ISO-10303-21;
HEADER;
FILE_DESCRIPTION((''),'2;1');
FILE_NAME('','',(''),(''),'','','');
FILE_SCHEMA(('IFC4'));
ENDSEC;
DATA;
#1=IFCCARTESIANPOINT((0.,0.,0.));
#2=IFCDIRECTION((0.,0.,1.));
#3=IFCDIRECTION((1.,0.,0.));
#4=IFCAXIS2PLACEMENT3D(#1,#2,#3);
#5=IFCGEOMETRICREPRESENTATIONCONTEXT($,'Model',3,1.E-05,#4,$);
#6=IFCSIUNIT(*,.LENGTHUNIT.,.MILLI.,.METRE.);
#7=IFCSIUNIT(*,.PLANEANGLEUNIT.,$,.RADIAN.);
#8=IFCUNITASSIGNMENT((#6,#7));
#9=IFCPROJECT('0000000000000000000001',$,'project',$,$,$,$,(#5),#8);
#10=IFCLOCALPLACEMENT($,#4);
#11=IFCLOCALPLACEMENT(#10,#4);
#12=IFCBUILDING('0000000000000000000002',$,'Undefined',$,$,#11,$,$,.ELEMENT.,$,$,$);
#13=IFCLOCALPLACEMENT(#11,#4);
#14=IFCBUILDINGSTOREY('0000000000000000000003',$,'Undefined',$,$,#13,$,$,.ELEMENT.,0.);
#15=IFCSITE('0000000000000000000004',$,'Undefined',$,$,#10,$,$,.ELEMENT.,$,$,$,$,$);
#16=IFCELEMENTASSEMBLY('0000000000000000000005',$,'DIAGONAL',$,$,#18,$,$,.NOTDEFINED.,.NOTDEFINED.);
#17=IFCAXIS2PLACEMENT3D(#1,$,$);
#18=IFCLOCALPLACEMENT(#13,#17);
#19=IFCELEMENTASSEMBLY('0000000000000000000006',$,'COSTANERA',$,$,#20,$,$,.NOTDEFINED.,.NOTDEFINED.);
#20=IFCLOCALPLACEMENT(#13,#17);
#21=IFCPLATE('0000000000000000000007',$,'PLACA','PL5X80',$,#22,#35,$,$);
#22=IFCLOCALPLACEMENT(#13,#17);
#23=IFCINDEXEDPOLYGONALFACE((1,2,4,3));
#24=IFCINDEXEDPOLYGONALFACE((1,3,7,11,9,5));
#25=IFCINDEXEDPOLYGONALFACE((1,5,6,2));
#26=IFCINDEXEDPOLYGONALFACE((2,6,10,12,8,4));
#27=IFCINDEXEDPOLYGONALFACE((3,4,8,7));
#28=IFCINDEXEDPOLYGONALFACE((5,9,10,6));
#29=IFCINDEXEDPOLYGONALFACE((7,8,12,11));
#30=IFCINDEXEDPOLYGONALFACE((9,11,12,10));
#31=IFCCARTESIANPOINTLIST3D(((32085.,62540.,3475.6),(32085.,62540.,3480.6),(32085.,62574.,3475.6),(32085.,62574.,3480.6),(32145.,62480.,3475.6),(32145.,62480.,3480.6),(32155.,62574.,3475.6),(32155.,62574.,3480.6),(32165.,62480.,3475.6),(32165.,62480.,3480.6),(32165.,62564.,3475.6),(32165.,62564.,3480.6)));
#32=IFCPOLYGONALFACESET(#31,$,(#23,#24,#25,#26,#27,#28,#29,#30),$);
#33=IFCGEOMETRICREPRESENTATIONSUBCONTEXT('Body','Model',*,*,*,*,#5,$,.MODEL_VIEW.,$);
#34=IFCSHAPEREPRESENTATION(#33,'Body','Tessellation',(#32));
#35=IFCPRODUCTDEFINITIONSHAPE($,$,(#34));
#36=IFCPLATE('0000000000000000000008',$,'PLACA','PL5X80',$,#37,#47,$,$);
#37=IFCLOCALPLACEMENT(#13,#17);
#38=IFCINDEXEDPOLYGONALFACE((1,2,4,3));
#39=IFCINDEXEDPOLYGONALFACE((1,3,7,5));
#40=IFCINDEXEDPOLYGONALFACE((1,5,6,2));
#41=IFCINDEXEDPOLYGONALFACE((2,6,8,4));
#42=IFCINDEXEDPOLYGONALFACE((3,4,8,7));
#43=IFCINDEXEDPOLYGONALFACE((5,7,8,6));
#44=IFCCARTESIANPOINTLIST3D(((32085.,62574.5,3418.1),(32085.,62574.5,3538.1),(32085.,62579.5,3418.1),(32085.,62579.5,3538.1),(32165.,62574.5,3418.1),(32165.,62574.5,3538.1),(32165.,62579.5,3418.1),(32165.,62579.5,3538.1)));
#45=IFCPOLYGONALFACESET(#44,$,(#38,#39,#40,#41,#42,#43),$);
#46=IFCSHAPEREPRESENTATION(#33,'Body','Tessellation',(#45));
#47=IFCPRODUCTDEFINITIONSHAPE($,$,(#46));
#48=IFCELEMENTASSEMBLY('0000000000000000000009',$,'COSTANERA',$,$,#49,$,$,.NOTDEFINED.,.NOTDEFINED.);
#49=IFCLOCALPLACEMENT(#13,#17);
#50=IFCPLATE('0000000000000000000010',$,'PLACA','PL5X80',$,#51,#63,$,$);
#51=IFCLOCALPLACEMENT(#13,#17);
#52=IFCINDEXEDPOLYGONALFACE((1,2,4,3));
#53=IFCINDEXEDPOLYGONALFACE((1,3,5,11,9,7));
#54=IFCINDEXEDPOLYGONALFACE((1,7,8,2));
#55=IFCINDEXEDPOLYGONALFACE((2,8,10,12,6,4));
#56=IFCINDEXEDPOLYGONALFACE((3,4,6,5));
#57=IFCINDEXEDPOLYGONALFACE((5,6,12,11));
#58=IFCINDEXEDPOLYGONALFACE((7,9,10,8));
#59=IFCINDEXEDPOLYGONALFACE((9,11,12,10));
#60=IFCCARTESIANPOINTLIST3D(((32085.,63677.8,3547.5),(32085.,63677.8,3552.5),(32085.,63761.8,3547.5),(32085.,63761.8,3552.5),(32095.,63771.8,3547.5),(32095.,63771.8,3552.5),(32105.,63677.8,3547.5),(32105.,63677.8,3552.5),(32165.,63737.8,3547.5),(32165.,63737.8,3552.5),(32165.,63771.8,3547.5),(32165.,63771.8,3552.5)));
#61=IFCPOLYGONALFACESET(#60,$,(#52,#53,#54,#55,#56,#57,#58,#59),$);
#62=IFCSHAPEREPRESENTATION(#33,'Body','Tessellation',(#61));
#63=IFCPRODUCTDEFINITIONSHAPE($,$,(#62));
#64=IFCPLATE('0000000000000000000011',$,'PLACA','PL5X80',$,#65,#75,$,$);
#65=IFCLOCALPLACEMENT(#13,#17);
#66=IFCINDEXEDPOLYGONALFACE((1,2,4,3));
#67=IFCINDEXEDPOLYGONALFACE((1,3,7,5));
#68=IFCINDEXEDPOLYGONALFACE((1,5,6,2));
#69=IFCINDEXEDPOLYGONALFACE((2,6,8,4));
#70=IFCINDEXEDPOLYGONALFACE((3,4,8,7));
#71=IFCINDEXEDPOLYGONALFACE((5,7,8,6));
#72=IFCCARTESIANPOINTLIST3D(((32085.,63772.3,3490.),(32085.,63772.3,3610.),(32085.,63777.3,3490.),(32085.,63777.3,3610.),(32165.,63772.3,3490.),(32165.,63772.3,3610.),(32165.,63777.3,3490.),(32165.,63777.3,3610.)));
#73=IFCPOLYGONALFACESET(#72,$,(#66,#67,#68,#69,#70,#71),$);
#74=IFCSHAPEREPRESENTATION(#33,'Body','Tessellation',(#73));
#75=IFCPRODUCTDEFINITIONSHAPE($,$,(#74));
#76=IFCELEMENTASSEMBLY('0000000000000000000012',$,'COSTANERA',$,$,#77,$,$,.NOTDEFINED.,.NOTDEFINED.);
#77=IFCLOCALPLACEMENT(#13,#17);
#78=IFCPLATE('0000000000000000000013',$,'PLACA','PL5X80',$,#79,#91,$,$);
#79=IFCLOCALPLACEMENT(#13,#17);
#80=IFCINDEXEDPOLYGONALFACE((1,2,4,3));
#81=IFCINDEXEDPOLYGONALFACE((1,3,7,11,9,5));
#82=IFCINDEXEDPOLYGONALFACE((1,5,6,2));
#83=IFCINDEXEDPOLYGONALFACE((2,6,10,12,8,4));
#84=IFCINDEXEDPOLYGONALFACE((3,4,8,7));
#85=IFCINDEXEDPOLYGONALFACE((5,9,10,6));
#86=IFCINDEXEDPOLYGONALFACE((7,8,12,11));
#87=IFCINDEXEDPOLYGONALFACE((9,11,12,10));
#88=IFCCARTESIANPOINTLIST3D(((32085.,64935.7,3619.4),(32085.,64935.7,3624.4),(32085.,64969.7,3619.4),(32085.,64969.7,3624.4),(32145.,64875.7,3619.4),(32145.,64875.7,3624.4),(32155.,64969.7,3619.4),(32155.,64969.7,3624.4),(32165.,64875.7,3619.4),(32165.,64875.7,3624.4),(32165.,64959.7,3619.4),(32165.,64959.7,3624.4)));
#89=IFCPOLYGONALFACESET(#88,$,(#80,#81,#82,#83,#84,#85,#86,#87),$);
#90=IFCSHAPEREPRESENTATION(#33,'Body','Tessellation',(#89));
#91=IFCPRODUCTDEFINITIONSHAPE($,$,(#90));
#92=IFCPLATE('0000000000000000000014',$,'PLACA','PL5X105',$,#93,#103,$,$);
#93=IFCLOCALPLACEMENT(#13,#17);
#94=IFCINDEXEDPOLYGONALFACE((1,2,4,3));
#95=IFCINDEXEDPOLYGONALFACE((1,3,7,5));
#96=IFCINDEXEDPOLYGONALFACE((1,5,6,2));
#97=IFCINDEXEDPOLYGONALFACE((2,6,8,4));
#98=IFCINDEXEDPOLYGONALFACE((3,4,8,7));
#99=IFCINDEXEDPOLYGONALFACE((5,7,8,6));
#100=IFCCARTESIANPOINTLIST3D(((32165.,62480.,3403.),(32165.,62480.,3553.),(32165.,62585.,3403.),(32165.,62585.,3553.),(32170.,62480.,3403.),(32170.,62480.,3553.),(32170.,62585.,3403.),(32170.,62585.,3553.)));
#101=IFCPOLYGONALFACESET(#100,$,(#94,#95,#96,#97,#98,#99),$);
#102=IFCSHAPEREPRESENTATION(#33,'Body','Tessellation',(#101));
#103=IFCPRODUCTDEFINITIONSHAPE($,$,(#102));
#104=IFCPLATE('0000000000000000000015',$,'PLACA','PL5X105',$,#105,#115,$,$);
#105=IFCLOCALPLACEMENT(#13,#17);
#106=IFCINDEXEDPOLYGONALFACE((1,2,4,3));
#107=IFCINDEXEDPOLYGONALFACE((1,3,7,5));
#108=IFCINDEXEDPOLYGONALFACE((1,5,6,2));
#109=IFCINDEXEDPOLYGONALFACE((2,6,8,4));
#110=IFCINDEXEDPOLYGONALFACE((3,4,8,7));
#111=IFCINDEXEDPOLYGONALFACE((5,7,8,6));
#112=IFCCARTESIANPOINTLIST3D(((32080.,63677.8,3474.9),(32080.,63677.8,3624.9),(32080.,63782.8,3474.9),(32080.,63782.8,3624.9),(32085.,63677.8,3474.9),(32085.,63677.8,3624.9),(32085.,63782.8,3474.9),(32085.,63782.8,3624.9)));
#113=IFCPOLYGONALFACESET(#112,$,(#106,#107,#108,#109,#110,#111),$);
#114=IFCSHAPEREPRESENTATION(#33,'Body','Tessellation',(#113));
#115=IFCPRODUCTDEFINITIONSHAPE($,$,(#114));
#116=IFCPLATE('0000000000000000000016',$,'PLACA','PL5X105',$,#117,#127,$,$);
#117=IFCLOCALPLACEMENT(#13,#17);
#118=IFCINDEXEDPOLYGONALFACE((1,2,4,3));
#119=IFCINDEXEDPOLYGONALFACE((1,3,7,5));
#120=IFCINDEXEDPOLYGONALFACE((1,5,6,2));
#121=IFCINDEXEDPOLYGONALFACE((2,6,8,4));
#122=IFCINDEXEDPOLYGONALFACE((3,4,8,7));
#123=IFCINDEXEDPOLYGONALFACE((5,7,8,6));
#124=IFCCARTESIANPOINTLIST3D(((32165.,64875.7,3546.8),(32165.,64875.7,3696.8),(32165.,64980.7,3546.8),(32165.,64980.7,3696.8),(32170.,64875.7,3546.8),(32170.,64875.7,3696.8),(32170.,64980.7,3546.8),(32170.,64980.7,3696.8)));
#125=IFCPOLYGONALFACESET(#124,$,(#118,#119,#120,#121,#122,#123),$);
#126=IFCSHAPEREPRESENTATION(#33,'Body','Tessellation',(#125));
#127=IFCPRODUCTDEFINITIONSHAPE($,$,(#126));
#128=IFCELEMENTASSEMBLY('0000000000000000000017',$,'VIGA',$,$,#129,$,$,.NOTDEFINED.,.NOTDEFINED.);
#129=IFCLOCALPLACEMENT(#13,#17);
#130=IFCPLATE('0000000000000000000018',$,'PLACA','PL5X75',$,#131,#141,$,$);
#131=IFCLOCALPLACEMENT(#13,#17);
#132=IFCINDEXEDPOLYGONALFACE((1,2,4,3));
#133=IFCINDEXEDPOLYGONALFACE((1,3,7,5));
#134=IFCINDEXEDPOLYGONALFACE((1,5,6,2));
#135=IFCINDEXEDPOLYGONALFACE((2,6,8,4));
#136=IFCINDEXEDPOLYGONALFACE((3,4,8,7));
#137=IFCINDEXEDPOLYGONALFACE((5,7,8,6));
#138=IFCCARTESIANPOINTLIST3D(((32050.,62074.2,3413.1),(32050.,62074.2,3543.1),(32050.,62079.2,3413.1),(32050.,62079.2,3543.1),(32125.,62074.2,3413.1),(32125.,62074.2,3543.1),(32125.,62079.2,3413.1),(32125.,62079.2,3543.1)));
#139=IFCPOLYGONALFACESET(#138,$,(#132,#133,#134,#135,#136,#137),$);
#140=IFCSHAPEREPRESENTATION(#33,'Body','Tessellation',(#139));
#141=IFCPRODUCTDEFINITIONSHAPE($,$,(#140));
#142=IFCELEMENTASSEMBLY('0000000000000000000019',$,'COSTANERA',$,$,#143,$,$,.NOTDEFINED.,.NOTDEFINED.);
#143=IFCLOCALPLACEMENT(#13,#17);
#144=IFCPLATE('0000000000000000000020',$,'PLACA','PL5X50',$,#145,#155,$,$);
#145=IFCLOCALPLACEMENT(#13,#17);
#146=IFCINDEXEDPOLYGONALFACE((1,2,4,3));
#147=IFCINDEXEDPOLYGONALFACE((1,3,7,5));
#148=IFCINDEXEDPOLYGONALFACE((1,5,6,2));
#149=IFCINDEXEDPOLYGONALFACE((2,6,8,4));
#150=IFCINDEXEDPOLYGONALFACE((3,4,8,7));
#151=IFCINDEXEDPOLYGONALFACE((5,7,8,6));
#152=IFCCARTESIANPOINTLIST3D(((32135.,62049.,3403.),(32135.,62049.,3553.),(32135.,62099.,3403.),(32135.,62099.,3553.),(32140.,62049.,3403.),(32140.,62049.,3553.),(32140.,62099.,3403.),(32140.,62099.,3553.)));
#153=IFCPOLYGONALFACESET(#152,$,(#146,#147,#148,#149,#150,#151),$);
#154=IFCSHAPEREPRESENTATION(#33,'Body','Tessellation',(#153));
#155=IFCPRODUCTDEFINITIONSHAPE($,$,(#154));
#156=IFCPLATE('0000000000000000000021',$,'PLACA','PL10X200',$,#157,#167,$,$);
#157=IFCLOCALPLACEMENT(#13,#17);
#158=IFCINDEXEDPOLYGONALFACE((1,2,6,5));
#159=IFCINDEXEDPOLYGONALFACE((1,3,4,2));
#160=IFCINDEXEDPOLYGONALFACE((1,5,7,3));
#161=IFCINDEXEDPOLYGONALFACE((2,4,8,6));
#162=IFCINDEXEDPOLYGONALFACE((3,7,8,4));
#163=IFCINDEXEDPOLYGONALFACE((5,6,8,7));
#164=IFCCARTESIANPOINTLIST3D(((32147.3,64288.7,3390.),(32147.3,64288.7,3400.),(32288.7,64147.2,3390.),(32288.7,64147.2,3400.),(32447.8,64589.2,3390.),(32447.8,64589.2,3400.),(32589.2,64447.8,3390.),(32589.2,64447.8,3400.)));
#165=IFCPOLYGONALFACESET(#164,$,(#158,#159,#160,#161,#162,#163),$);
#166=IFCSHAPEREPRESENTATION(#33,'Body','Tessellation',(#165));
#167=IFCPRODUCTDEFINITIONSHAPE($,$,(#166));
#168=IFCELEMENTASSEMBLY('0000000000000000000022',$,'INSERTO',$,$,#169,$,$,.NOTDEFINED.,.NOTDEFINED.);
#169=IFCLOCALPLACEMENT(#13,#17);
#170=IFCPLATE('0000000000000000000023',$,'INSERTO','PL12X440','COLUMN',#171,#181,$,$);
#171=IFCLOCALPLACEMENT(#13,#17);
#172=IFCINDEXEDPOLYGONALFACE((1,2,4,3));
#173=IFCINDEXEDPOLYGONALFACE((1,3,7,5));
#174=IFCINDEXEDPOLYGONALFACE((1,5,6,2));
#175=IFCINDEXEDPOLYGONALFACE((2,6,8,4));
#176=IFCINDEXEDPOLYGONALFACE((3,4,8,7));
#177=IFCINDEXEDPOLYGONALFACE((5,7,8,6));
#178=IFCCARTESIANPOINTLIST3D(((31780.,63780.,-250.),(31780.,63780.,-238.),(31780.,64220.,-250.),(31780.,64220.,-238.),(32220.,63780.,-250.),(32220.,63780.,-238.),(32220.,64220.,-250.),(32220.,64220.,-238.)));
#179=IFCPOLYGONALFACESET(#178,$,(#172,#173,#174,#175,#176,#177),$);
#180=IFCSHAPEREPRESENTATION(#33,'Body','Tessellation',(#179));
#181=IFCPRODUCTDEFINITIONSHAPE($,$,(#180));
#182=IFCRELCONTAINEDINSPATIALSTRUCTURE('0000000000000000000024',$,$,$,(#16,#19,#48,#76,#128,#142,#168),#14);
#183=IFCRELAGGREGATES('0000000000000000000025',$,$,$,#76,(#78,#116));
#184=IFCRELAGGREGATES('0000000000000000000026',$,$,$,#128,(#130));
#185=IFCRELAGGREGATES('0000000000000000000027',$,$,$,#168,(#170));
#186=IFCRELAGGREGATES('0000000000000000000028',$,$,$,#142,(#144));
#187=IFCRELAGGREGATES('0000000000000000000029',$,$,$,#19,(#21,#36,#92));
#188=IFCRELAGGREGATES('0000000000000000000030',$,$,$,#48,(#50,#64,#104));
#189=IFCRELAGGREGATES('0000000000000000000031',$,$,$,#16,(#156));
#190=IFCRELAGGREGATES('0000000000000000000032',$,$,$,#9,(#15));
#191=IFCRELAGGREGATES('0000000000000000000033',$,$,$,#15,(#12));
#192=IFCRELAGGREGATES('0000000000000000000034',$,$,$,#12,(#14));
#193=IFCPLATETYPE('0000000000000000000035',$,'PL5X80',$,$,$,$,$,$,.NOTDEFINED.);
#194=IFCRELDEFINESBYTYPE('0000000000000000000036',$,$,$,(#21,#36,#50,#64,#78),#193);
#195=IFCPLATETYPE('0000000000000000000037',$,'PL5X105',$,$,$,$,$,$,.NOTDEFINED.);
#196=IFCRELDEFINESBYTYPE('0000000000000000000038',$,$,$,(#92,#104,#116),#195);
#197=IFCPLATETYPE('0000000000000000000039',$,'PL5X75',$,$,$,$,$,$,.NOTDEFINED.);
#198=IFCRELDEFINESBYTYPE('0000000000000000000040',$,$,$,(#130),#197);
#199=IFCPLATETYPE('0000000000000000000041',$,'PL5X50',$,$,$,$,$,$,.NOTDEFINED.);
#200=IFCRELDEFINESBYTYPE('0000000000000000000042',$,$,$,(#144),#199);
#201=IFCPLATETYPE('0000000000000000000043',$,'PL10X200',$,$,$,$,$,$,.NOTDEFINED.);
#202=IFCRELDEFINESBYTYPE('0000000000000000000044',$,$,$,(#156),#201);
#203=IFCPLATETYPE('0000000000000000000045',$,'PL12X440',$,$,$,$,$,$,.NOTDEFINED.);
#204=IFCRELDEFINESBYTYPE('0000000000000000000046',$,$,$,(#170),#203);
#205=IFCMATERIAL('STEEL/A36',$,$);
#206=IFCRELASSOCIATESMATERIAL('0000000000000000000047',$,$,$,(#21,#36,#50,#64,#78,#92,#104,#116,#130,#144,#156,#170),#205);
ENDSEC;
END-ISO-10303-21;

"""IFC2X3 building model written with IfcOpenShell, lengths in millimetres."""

from ifc_helpers import new_model, si_unit, frame, origin_with_axes, place, context, subcontext, project, spatial, polyline, outline, extrude, material, type_object, element, aggregate, save


model = new_model("IFC2X3")

# Units and contexts
model_context = context("Model", 3, precision=1e-05, world=origin_with_axes())
body_context = subcontext(model_context, "Body", "Model", "MODEL_VIEW")
ifc_project = project(units=[si_unit("LENGTHUNIT", "METRE", prefix="MILLI"), si_unit("PLANEANGLEUNIT", "RADIAN")], contexts=[model_context])

# Site, building, storey
site_placement = place(None, origin_with_axes())
site = spatial("IfcSite", under=ifc_project, at=site_placement, Name="Undefined", CompositionType="ELEMENT")
building_placement = place(site_placement, origin_with_axes())
building = spatial("IfcBuilding", under=site, at=building_placement, Name="Undefined", CompositionType="ELEMENT")
storey_placement = place(building_placement, origin_with_axes())
storey = spatial("IfcBuildingStorey", under=building, at=storey_placement, Name="Undefined", CompositionType="ELEMENT", Elevation=0.0)

# Shared definitions
ifc_material_1 = material(Name="STEEL/A36")

# Element assembly
assembly_1_placement = place(storey_placement, origin_with_axes())
assembly_1 = element("IfcElementAssembly", 1, at=assembly_1_placement, inside=storey, Name="DIAGONAL", AssemblyPlace="NOTDEFINED", PredefinedType="NOTDEFINED")

# Element assemblies, plates
assembly_2_placement = place(storey_placement, origin_with_axes())
assembly_2 = element("IfcElementAssembly", 2, at=assembly_2_placement, inside=storey, Name="COSTANERA", AssemblyPlace="NOTDEFINED", PredefinedType="NOTDEFINED")
plate_type_1 = type_object("IfcPlateType", Name="PL5X80", PredefinedType="NOTDEFINED")
plate_1_placement = place(assembly_2_placement, frame((32085.0, 62574.0, 3478.1), z_axis=(0.0, 0.0, -1.0), x_axis=(1.0, 0.0, 0.0)))
plate_1 = element("IfcPlate", 3, at=plate_1_placement, type_object=plate_type_1, material=ifc_material_1, Name="PLACA", Description="PL5X80", context=body_context, shape_type="SweptSolid", body=[
    extrude(outline(polyline([(0.0, 0.0), (70.0, 0.0), (80.0, 10.0), (80.0, 94.0), (60.0, 94.0), (0.0, 34.0), (0.0, 0.0)])), frame((0.0, 0.0, -2.5), z_axis=(0.0, 0.0, 1.0), x_axis=(1.0, 0.0, 0.0)), (0.0, 0.0, 1.0), 5.0),
])
plate_2_placement = place(assembly_2_placement, frame((32085.0, 62577.0, 3538.1), z_axis=(0.0, 1.0, 0.0), x_axis=(1.0, 0.0, 0.0)))
plate_2 = element("IfcPlate", 4, at=plate_2_placement, type_object=plate_type_1, material=ifc_material_1, Name="PLACA", Description="PL5X80", context=body_context, shape_type="SweptSolid", body=[
    extrude(outline(polyline([(0.0, 0.0), (80.0, 0.0), (80.0, 120.0), (0.0, 120.0), (0.0, 0.0)])), frame((0.0, 0.0, -2.5), z_axis=(0.0, 0.0, 1.0), x_axis=(1.0, 0.0, 0.0)), (0.0, 0.0, 1.0), 5.0),
])
assembly_3_placement = place(storey_placement, origin_with_axes())
assembly_3 = element("IfcElementAssembly", 5, at=assembly_3_placement, inside=storey, Name="COSTANERA", AssemblyPlace="NOTDEFINED", PredefinedType="NOTDEFINED")
plate_3_placement = place(assembly_3_placement, frame((32165.0, 63771.8, 3550.0), z_axis=(0.0, 0.0, 1.0), x_axis=(-1.0, 0.0, 0.0)))
plate_3 = element("IfcPlate", 6, at=plate_3_placement, type_object=plate_type_1, material=ifc_material_1, Name="PLACA", Description="PL5X80", context=body_context, shape_type="SweptSolid", body=[
    extrude(outline(polyline([(0.0, 0.0), (70.0, 0.0), (80.0, 10.0), (80.0, 94.0), (60.0, 94.0), (0.0, 34.0), (0.0, 0.0)])), frame((0.0, 0.0, -2.5), z_axis=(0.0, 0.0, 1.0), x_axis=(1.0, 0.0, 0.0)), (0.0, 0.0, 1.0), 5.0),
])
plate_4_placement = place(assembly_3_placement, frame((32165.0, 63774.8, 3610.0), z_axis=(0.0, -1.0, 0.0), x_axis=(-1.0, 0.0, 0.0)))
plate_4 = element("IfcPlate", 7, at=plate_4_placement, type_object=plate_type_1, material=ifc_material_1, Name="PLACA", Description="PL5X80", context=body_context, shape_type="SweptSolid", body=[
    extrude(outline(polyline([(0.0, 0.0), (80.0, 0.0), (80.0, 120.0), (0.0, 120.0), (0.0, 0.0)])), frame((0.0, 0.0, -2.5), z_axis=(0.0, 0.0, 1.0), x_axis=(1.0, 0.0, 0.0)), (0.0, 0.0, 1.0), 5.0),
])

# Element assembly, plate
assembly_4_placement = place(storey_placement, origin_with_axes())
assembly_4 = element("IfcElementAssembly", 8, at=assembly_4_placement, inside=storey, Name="COSTANERA", AssemblyPlace="NOTDEFINED", PredefinedType="NOTDEFINED")
plate_5_placement = place(assembly_4_placement, frame((32085.0, 64969.7, 3621.9), z_axis=(0.0, 0.0, -1.0), x_axis=(1.0, 0.0, 0.0)))
plate_5 = element("IfcPlate", 9, at=plate_5_placement, type_object=plate_type_1, material=ifc_material_1, Name="PLACA", Description="PL5X80", context=body_context, shape_type="SweptSolid", body=[
    extrude(outline(polyline([(0.0, 0.0), (70.0, 0.0), (80.0, 10.0), (80.0, 94.0), (60.0, 94.0), (0.0, 34.0), (0.0, 0.0)])), frame((0.0, 0.0, -2.5), z_axis=(0.0, 0.0, 1.0), x_axis=(1.0, 0.0, 0.0)), (0.0, 0.0, 1.0), 5.0),
])

# Plates
plate_type_2 = type_object("IfcPlateType", Name="PL5X105", PredefinedType="NOTDEFINED")
plate_6_placement = place(assembly_2_placement, frame((32167.5, 62480.0, 3403.0), z_axis=(1.0, 0.0, 0.0), x_axis=(0.0, 1.0, 0.0)))
plate_6 = element("IfcPlate", 10, at=plate_6_placement, type_object=plate_type_2, material=ifc_material_1, Name="PLACA", Description="PL5X105", context=body_context, shape_type="SweptSolid", body=[
    extrude(outline(polyline([(0.0, 0.0), (105.0, 0.0), (105.0, 150.0), (0.0, 150.0), (0.0, 0.0)])), frame((0.0, 0.0, -2.5), z_axis=(0.0, 0.0, 1.0), x_axis=(1.0, 0.0, 0.0)), (0.0, 0.0, 1.0), 5.0),
])
plate_7_placement = place(assembly_3_placement, frame((32082.5, 63782.8, 3474.9), z_axis=(-1.0, 0.0, 0.0), x_axis=(0.0, -1.0, 0.0)))
plate_7 = element("IfcPlate", 11, at=plate_7_placement, type_object=plate_type_2, material=ifc_material_1, Name="PLACA", Description="PL5X105", context=body_context, shape_type="SweptSolid", body=[
    extrude(outline(polyline([(0.0, 0.0), (105.0, 0.0), (105.0, 150.0), (0.0, 150.0), (0.0, 0.0)])), frame((0.0, 0.0, -2.5), z_axis=(0.0, 0.0, 1.0), x_axis=(1.0, 0.0, 0.0)), (0.0, 0.0, 1.0), 5.0),
])
plate_8_placement = place(assembly_4_placement, frame((32167.5, 64875.7, 3546.8), z_axis=(1.0, 0.0, 0.0), x_axis=(0.0, 1.0, 0.0)))
plate_8 = element("IfcPlate", 12, at=plate_8_placement, type_object=plate_type_2, material=ifc_material_1, Name="PLACA", Description="PL5X105", context=body_context, shape_type="SweptSolid", body=[
    extrude(outline(polyline([(0.0, 0.0), (105.0, 0.0), (105.0, 150.0), (0.0, 150.0), (0.0, 0.0)])), frame((0.0, 0.0, -2.5), z_axis=(0.0, 0.0, 1.0), x_axis=(1.0, 0.0, 0.0)), (0.0, 0.0, 1.0), 5.0),
])
aggregate(assembly_4, [plate_5, plate_8])

# Element assemblies, plates
assembly_5_placement = place(storey_placement, origin_with_axes())
assembly_5 = element("IfcElementAssembly", 13, at=assembly_5_placement, inside=storey, Name="VIGA", AssemblyPlace="NOTDEFINED", PredefinedType="NOTDEFINED")
plate_type_3 = type_object("IfcPlateType", Name="PL5X75", PredefinedType="NOTDEFINED")
plate_9_placement = place(assembly_5_placement, frame((32125.0, 62076.7, 3543.1), z_axis=(0.0, -1.0, 0.0), x_axis=(-1.0, 0.0, 0.0)))
plate_9 = element("IfcPlate", 14, at=plate_9_placement, type_object=plate_type_3, material=ifc_material_1, Name="PLACA", Description="PL5X75", context=body_context, shape_type="SweptSolid", body=[
    extrude(outline(polyline([(0.0, 0.0), (75.0, 0.0), (75.0, 130.0), (0.0, 130.0), (0.0, 0.0)])), frame((0.0, 0.0, -2.5), z_axis=(0.0, 0.0, 1.0), x_axis=(1.0, 0.0, 0.0)), (0.0, 0.0, 1.0), 5.0),
])
aggregate(assembly_5, [plate_9])
assembly_6_placement = place(storey_placement, origin_with_axes())
assembly_6 = element("IfcElementAssembly", 15, at=assembly_6_placement, inside=storey, Name="COSTANERA", AssemblyPlace="NOTDEFINED", PredefinedType="NOTDEFINED")
plate_type_4 = type_object("IfcPlateType", Name="PL5X50", PredefinedType="NOTDEFINED")
plate_10_placement = place(assembly_6_placement, frame((32137.5, 62049.0, 3403.0), z_axis=(1.0, 0.0, 0.0), x_axis=(0.0, 1.0, 0.0)))
plate_10 = element("IfcPlate", 16, at=plate_10_placement, type_object=plate_type_4, material=ifc_material_1, Name="PLACA", Description="PL5X50", context=body_context, shape_type="SweptSolid", body=[
    extrude(outline(polyline([(0.0, 0.0), (50.0, 0.0), (50.0, 150.0), (0.0, 150.0), (0.0, 0.0)])), frame((0.0, 0.0, -2.5), z_axis=(0.0, 0.0, 1.0), x_axis=(1.0, 0.0, 0.0)), (0.0, 0.0, 1.0), 5.0),
])

# Plate
plate_type_5 = type_object("IfcPlateType", Name="PL10X200", PredefinedType="NOTDEFINED")
plate_11_placement = place(assembly_1_placement, frame((32218.0, 64218.0, 3395.0), z_axis=(0.0, 0.0, -1.0), x_axis=(0.707107, 0.707107, 0.0)))
plate_11 = element("IfcPlate", 17, at=plate_11_placement, type_object=plate_type_5, material=ifc_material_1, Name="PLACA", Description="PL10X200", context=body_context, shape_type="SweptSolid", body=[
    extrude(outline(polyline([(0.0, -100.0), (0.0, 100.0), (425.0, 100.0), (425.0, -100.0), (0.0, -100.0)])), frame((0.0, 0.0, -5.0), z_axis=(0.0, 0.0, 1.0), x_axis=(1.0, 0.0, 0.0)), (0.0, 0.0, 1.0), 10.0),
])

# Element assembly, plate
assembly_7_placement = place(storey_placement, origin_with_axes())
assembly_7 = element("IfcElementAssembly", 18, at=assembly_7_placement, inside=storey, Name="INSERTO", AssemblyPlace="NOTDEFINED", PredefinedType="NOTDEFINED")
plate_type_6 = type_object("IfcPlateType", Name="PL12X440", PredefinedType="NOTDEFINED")
plate_12_placement = place(assembly_7_placement, frame((32220.0, 64000.0, -244.0), z_axis=(0.0, 0.0, 1.0), x_axis=(-1.0, 0.0, 0.0)))
plate_12 = element("IfcPlate", 19, at=plate_12_placement, type_object=plate_type_6, material=ifc_material_1, Name="INSERTO", Description="PL12X440", ObjectType="COLUMN", context=body_context, shape_type="SweptSolid", body=[
    extrude(outline(polyline([(0.0, -220.0), (0.0, 220.0), (440.0, 220.0), (440.0, -220.0), (0.0, -220.0)])), frame((0.0, 0.0, -6.0), z_axis=(0.0, 0.0, 1.0), x_axis=(1.0, 0.0, 0.0)), (0.0, 0.0, 1.0), 12.0),
])
aggregate(assembly_7, [plate_12])

aggregate(assembly_6, [plate_10])
aggregate(assembly_2, [plate_1, plate_2, plate_6])
aggregate(assembly_3, [plate_3, plate_4, plate_7])
aggregate(assembly_1, [plate_11])

save(model, "model.ifc")
